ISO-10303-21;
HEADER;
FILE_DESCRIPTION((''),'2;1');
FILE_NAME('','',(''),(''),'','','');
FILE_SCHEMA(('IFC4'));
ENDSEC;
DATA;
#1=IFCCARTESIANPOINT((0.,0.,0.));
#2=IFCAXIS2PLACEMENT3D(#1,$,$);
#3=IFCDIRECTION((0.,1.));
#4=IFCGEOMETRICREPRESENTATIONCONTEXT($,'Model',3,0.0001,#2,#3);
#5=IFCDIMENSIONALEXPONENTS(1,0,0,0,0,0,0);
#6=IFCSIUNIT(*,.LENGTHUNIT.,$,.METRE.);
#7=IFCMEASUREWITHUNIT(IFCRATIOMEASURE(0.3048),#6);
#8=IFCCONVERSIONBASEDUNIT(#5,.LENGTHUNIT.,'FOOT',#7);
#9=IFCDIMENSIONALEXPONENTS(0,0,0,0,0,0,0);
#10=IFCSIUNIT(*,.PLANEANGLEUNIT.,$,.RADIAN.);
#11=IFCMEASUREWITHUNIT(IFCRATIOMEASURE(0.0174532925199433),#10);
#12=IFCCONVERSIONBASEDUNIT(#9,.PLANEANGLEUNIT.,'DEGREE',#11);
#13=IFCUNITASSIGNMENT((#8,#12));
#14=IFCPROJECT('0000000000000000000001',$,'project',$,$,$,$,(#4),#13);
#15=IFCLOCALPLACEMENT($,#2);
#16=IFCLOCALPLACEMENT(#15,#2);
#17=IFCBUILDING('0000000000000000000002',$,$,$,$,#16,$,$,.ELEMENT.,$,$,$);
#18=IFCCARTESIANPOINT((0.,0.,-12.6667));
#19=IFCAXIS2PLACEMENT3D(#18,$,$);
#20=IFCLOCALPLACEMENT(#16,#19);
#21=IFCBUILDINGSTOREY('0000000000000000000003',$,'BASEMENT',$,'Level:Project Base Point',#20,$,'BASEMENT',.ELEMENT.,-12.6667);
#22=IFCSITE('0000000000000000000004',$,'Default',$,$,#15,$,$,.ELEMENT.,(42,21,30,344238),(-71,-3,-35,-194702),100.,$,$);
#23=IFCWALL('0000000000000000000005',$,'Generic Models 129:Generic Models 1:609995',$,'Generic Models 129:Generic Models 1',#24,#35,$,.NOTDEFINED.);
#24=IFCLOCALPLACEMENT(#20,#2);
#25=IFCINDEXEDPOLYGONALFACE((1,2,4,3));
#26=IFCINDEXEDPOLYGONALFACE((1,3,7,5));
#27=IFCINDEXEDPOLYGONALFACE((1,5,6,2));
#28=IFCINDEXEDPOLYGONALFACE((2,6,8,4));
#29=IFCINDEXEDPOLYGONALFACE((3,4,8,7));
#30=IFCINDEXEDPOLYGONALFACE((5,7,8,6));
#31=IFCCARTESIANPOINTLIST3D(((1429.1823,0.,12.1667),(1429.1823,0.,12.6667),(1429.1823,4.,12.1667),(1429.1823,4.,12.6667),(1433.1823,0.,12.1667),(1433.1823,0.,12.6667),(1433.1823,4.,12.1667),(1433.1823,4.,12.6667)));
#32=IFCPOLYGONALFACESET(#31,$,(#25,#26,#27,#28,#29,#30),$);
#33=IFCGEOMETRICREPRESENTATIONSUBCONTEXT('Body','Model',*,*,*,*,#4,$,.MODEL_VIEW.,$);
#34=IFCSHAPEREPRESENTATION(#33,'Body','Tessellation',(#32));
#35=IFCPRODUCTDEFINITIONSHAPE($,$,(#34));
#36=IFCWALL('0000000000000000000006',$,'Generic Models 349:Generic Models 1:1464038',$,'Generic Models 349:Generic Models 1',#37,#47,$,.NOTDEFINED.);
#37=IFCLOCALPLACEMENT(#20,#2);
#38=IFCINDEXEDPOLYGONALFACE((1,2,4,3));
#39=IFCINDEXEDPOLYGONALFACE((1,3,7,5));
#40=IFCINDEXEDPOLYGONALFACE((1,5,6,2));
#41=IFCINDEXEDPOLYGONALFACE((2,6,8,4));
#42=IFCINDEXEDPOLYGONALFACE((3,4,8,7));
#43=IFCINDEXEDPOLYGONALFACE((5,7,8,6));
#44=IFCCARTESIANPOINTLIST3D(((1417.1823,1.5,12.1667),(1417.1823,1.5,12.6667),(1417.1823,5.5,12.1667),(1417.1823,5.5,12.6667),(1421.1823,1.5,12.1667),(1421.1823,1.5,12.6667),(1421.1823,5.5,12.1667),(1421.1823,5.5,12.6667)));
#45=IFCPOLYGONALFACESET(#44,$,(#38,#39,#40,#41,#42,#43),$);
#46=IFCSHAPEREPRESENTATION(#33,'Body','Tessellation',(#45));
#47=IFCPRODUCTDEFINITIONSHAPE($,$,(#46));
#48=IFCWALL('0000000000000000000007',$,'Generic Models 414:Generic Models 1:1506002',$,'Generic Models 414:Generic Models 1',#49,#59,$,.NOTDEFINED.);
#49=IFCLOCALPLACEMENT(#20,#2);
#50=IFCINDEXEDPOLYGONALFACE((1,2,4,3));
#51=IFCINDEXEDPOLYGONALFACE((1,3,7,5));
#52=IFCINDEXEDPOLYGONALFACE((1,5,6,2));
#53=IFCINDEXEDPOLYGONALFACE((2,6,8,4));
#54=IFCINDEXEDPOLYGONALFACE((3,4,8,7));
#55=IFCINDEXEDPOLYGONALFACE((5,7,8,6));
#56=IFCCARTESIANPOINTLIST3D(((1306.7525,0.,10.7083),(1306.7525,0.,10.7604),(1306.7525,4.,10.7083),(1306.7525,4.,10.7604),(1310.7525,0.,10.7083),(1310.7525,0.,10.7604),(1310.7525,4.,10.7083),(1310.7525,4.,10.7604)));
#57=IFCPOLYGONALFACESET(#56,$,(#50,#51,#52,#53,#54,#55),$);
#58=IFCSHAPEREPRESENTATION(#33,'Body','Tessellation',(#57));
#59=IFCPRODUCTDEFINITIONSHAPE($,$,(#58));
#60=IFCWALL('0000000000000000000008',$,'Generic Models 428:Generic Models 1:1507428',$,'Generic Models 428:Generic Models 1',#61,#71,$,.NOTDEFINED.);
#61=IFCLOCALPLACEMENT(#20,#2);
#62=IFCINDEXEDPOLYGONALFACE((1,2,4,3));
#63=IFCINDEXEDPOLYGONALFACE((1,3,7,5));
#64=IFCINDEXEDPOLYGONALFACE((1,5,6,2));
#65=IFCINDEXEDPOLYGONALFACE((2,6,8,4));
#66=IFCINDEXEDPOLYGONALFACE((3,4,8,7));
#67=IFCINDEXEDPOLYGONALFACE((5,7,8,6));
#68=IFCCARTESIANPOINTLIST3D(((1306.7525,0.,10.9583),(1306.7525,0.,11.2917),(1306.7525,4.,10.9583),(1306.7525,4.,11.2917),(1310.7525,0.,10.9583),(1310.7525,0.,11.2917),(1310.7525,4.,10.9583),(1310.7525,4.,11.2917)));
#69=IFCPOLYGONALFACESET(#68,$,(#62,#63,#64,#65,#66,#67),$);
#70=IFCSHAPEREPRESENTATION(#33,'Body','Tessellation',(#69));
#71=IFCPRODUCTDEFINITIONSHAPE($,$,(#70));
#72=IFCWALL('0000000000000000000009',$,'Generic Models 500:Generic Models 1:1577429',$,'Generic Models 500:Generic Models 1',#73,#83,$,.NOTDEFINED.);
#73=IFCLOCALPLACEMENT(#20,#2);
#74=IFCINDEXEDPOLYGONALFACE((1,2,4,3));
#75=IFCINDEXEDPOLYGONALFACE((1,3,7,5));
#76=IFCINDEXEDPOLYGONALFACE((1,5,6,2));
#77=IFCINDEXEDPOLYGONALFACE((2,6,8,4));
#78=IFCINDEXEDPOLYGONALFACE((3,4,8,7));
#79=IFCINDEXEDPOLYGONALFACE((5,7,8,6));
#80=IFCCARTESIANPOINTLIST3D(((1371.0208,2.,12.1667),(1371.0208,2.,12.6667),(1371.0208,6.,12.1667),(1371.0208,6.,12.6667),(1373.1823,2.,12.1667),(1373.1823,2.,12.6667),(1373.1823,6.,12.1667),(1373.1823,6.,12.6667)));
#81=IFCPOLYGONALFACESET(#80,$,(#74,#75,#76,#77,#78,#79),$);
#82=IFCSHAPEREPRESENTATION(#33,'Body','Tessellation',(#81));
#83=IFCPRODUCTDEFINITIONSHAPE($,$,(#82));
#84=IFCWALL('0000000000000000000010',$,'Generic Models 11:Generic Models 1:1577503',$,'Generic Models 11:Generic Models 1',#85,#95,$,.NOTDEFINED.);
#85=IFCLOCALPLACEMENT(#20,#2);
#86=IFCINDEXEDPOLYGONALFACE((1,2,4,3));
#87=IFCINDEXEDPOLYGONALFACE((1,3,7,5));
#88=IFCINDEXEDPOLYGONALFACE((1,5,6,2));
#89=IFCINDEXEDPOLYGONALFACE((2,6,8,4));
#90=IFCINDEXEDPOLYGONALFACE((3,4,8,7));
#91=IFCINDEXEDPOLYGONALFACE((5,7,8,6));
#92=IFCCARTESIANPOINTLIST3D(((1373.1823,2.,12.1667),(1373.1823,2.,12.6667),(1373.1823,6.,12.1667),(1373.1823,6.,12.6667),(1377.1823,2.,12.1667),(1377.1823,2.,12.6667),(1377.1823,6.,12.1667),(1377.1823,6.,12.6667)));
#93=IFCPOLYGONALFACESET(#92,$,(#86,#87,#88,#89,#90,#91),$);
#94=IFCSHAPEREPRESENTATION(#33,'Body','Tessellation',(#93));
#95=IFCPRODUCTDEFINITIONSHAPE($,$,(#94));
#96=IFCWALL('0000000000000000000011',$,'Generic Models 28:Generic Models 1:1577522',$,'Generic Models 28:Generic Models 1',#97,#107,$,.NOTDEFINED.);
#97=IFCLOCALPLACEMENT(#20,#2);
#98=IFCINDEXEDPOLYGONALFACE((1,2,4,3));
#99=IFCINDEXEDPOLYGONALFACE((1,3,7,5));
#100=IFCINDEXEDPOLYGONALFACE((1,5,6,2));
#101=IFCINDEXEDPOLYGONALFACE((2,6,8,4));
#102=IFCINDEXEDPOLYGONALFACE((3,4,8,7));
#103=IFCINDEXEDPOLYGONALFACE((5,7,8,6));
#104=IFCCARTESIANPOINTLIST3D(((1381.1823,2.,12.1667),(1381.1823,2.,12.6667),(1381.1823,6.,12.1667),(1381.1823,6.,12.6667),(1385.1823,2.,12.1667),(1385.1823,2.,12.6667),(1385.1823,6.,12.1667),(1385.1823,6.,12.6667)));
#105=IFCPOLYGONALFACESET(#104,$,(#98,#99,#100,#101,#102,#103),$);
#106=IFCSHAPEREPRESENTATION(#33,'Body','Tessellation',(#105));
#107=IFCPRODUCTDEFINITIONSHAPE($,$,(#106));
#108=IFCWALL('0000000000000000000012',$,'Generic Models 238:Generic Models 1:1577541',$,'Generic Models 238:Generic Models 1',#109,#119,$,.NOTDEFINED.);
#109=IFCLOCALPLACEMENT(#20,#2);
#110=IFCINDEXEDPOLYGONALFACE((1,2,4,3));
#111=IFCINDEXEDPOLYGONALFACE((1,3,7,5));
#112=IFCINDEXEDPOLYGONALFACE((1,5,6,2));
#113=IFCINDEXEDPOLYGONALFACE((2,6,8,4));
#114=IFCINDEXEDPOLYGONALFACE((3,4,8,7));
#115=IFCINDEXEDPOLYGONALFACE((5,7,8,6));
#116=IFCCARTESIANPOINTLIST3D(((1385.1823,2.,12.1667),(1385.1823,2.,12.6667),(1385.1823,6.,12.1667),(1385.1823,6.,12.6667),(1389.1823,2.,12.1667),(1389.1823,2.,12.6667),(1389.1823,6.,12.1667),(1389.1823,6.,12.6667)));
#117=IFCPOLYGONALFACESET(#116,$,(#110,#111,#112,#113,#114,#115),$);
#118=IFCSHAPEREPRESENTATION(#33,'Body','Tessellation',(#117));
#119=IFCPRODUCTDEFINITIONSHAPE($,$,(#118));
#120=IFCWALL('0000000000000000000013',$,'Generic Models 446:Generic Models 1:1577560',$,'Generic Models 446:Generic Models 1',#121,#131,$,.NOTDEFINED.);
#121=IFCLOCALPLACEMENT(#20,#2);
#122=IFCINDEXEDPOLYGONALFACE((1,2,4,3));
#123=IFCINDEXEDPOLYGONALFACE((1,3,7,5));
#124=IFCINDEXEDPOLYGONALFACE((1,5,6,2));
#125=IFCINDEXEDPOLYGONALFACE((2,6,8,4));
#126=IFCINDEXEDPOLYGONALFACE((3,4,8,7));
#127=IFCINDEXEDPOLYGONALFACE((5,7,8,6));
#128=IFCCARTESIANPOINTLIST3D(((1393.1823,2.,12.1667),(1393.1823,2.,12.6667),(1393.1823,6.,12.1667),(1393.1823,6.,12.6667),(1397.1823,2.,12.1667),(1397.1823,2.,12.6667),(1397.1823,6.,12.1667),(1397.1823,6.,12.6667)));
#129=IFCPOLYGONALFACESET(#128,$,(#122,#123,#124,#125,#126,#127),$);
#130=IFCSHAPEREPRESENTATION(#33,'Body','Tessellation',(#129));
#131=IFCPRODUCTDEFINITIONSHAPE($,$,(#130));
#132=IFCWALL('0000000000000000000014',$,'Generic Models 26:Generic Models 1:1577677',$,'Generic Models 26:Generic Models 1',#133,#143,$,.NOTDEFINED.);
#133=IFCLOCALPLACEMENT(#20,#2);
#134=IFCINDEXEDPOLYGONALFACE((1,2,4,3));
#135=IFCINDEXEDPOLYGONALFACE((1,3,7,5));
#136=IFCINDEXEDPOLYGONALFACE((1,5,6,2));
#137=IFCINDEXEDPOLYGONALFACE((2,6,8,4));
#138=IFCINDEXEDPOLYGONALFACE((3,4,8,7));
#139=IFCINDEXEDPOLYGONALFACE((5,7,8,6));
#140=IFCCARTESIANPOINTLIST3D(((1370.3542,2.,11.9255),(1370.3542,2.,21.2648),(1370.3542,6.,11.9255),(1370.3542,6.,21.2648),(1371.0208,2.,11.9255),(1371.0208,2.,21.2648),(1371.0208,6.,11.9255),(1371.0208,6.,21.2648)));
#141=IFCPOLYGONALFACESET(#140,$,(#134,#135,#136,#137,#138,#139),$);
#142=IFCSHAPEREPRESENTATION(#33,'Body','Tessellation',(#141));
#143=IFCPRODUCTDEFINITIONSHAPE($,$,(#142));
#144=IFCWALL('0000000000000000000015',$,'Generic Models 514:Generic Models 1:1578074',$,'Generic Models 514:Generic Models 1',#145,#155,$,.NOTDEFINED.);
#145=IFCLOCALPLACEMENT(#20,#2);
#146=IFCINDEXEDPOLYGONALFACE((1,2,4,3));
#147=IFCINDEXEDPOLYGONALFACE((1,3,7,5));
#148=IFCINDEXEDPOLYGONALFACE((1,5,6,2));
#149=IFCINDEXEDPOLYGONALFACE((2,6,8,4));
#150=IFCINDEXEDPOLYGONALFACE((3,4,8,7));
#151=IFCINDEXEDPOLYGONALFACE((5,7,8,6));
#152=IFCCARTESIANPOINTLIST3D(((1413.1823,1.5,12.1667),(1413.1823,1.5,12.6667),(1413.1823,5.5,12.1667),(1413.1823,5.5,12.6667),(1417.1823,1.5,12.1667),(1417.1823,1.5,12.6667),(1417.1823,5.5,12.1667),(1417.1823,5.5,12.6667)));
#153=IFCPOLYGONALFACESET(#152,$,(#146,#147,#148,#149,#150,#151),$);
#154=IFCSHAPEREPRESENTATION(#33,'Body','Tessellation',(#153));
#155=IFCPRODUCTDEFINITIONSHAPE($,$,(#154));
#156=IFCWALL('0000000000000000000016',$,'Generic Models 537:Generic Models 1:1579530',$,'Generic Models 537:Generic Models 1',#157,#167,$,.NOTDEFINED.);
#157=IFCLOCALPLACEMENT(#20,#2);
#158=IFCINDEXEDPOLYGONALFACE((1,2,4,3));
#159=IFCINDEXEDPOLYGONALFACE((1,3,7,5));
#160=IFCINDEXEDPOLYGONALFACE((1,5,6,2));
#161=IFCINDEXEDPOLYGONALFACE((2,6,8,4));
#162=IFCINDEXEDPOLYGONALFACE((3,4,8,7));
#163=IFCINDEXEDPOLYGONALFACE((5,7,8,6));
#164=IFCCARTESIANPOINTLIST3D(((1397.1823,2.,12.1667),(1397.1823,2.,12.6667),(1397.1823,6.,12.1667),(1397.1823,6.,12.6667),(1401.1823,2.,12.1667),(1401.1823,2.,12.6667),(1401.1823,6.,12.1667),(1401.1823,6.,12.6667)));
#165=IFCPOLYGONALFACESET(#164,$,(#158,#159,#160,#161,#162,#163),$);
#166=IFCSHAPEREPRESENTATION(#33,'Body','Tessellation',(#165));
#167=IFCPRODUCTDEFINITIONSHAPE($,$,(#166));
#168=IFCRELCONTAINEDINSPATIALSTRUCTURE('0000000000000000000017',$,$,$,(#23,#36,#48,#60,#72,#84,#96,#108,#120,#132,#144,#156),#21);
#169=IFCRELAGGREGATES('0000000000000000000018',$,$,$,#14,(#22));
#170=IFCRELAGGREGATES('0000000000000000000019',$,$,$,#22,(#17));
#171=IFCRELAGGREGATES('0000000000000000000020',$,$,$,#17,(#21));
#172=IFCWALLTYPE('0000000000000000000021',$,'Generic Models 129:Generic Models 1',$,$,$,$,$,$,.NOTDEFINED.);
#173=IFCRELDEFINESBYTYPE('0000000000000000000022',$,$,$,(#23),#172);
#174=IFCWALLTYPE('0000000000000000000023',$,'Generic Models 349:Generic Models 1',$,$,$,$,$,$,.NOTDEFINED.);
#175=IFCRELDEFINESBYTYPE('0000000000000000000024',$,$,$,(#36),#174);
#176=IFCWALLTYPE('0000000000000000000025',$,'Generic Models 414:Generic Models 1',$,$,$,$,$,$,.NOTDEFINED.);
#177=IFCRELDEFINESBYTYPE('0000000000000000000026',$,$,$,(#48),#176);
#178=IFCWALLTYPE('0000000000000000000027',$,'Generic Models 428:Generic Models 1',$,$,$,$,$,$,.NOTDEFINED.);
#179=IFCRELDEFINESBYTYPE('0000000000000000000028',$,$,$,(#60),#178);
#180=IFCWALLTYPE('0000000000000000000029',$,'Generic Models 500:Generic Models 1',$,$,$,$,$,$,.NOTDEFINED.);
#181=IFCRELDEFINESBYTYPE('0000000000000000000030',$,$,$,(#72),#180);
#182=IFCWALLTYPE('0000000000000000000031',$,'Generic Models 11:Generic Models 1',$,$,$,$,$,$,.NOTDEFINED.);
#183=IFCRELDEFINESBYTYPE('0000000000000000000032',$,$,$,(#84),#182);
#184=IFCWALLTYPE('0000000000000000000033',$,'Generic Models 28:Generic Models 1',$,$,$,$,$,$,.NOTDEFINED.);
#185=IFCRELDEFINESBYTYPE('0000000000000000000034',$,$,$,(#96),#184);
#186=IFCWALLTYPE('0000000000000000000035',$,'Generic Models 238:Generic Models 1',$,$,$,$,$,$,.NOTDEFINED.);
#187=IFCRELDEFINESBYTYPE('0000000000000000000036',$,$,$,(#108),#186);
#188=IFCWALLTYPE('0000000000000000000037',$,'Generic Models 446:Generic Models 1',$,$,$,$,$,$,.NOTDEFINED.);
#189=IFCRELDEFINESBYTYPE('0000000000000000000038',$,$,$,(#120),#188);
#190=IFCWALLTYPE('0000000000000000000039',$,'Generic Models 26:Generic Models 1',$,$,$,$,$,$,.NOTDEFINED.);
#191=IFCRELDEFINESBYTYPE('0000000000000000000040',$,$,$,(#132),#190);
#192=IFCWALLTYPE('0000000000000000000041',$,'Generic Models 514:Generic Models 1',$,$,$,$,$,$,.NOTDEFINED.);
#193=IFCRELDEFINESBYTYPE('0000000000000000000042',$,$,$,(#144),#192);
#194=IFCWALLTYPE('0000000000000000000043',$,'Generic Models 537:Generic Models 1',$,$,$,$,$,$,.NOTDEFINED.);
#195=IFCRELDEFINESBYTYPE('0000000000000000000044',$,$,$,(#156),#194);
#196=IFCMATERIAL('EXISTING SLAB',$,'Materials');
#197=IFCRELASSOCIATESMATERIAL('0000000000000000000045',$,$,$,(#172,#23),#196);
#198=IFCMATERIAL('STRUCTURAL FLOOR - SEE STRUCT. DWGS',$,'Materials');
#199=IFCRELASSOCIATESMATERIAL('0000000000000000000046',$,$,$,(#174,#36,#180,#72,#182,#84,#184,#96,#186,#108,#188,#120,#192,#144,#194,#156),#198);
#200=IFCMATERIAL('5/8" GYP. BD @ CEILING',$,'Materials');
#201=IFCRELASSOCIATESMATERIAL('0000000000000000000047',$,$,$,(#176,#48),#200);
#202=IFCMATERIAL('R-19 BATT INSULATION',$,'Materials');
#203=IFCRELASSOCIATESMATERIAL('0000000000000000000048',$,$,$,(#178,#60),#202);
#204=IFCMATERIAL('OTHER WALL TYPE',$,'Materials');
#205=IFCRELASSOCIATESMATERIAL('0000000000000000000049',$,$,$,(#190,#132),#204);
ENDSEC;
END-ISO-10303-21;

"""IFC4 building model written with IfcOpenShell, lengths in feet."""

from ifc_helpers import new_model, entity, si_unit, converted_unit, direction, frame, frame_2d, origin, origin_2d_with_axis, place, context, subcontext, project, spatial, rectangle, extrude, material, type_object, element, save


model = new_model("IFC4")

# Units and contexts
model_context = context("Model", 3, precision=0.0001, world=origin(), true_north=direction((0.0, 1.0)))
body_context = subcontext(model_context, "Body", "Model", "MODEL_VIEW")
ifc_project = project(units=[converted_unit("LENGTHUNIT", "FOOT", entity("IfcRatioMeasure", 0.3048), si_unit("LENGTHUNIT", "METRE"), dimensions=[1, 0, 0, 0, 0, 0, 0]), converted_unit("PLANEANGLEUNIT", "DEGREE", entity("IfcRatioMeasure", 0.0174532925199433), si_unit("PLANEANGLEUNIT", "RADIAN"), dimensions=[0, 0, 0, 0, 0, 0, 0])], contexts=[model_context])

# Site, building, storey
site_placement = place(None, origin())
site = spatial("IfcSite", under=ifc_project, at=site_placement, Name="Default", CompositionType="ELEMENT", RefLatitude=(42, 21, 30, 344238), RefLongitude=(-71, -3, -35, -194702), RefElevation=100.0)
building_placement = place(site_placement, origin())
building = spatial("IfcBuilding", under=site, at=building_placement, CompositionType="ELEMENT")
storey_placement = place(building_placement, frame((0.0, 0.0, -12.6667)))
storey = spatial("IfcBuildingStorey", under=building, at=storey_placement, Name="BASEMENT", ObjectType="Level:Project Base Point", LongName="BASEMENT", CompositionType="ELEMENT", Elevation=-12.6667)

# Walls
ifc_material_1 = material(Name="EXISTING SLAB", Category="Materials")
wall_type_1 = type_object("IfcWallType", Name="Generic Models 129:Generic Models 1", PredefinedType="NOTDEFINED", material=ifc_material_1)
wall_1_placement = place(storey_placement, frame((1429.1823, 0.0, 12.1667), z_axis=(0.0, 0.0, 1.0), x_axis=(0.0, 1.0, 0.0)))
element("IfcWall", 1, at=wall_1_placement, inside=storey, type_object=wall_type_1, material=ifc_material_1, Name="Generic Models 129:Generic Models 1:609995", ObjectType="Generic Models 129:Generic Models 1", PredefinedType="NOTDEFINED", context=body_context, shape_type="SweptSolid", body=[
    extrude(rectangle(XDim=4.0, YDim=4.0, at=frame_2d((0.0, 0.0), x_axis=(1.0, 0.0))), frame((2.0, -2.0, 0.0)), (0.0, 0.0, 1.0), 0.5),
])
ifc_material_2 = material(Name="STRUCTURAL FLOOR - SEE STRUCT. DWGS", Category="Materials")
wall_type_2 = type_object("IfcWallType", Name="Generic Models 349:Generic Models 1", PredefinedType="NOTDEFINED", material=ifc_material_2)
wall_2_placement = place(storey_placement, frame((1417.1823, 1.5, 12.1667), z_axis=(0.0, 0.0, 1.0), x_axis=(0.0, 1.0, 0.0)))
element("IfcWall", 2, at=wall_2_placement, inside=storey, type_object=wall_type_2, material=ifc_material_2, Name="Generic Models 349:Generic Models 1:1464038", ObjectType="Generic Models 349:Generic Models 1", PredefinedType="NOTDEFINED", context=body_context, shape_type="SweptSolid", body=[
    extrude(rectangle(XDim=4.0, YDim=4.0, at=frame_2d((0.0, 0.0), x_axis=(1.0, 0.0))), frame((2.0, -2.0, 0.0)), (0.0, 0.0, 1.0), 0.5),
])
ifc_material_3 = material(Name="5/8\" GYP. BD @ CEILING", Category="Materials")
wall_type_3 = type_object("IfcWallType", Name="Generic Models 414:Generic Models 1", PredefinedType="NOTDEFINED", material=ifc_material_3)
wall_3_placement = place(storey_placement, frame((1306.7525, 0.0, 10.7083), z_axis=(0.0, 0.0, 1.0), x_axis=(0.0, 1.0, 0.0)))
element("IfcWall", 3, at=wall_3_placement, inside=storey, type_object=wall_type_3, material=ifc_material_3, Name="Generic Models 414:Generic Models 1:1506002", ObjectType="Generic Models 414:Generic Models 1", PredefinedType="NOTDEFINED", context=body_context, shape_type="SweptSolid", body=[
    extrude(rectangle(XDim=4.0, YDim=4.0, at=origin_2d_with_axis()), frame((2.0, -2.0, 0.0)), (0.0, 0.0, 1.0), 0.0521),
])
ifc_material_4 = material(Name="R-19 BATT INSULATION", Category="Materials")
wall_type_4 = type_object("IfcWallType", Name="Generic Models 428:Generic Models 1", PredefinedType="NOTDEFINED", material=ifc_material_4)
wall_4_placement = place(storey_placement, frame((1306.7525, 0.0, 10.9583), z_axis=(0.0, 0.0, 1.0), x_axis=(0.0, 1.0, 0.0)))
element("IfcWall", 4, at=wall_4_placement, inside=storey, type_object=wall_type_4, material=ifc_material_4, Name="Generic Models 428:Generic Models 1:1507428", ObjectType="Generic Models 428:Generic Models 1", PredefinedType="NOTDEFINED", context=body_context, shape_type="SweptSolid", body=[
    extrude(rectangle(XDim=4.0, YDim=4.0, at=origin_2d_with_axis()), frame((2.0, -2.0, 0.0)), (0.0, 0.0, 1.0), 0.3333),
])
wall_type_5 = type_object("IfcWallType", Name="Generic Models 500:Generic Models 1", PredefinedType="NOTDEFINED", material=ifc_material_2)
wall_5_placement = place(storey_placement, frame((1371.0208, 2.0, 12.1667), z_axis=(0.0, 0.0, 1.0), x_axis=(0.0, 1.0, 0.0)))
element("IfcWall", 5, at=wall_5_placement, inside=storey, type_object=wall_type_5, material=ifc_material_2, Name="Generic Models 500:Generic Models 1:1577429", ObjectType="Generic Models 500:Generic Models 1", PredefinedType="NOTDEFINED", context=body_context, shape_type="SweptSolid", body=[
    extrude(rectangle(XDim=4.0, YDim=2.1615, at=frame_2d((0.0, 0.0), x_axis=(1.0, 0.0))), frame((2.0, -1.0807, 0.0)), (0.0, 0.0, 1.0), 0.5),
])
wall_type_6 = type_object("IfcWallType", Name="Generic Models 11:Generic Models 1", PredefinedType="NOTDEFINED", material=ifc_material_2)
wall_6_placement = place(storey_placement, frame((1373.1823, 2.0, 12.1667), z_axis=(0.0, 0.0, 1.0), x_axis=(0.0, 1.0, 0.0)))
element("IfcWall", 6, at=wall_6_placement, inside=storey, type_object=wall_type_6, material=ifc_material_2, Name="Generic Models 11:Generic Models 1:1577503", ObjectType="Generic Models 11:Generic Models 1", PredefinedType="NOTDEFINED", context=body_context, shape_type="SweptSolid", body=[
    extrude(rectangle(XDim=4.0, YDim=4.0, at=origin_2d_with_axis()), frame((2.0, -2.0, 0.0)), (0.0, 0.0, 1.0), 0.5),
])
wall_type_7 = type_object("IfcWallType", Name="Generic Models 28:Generic Models 1", PredefinedType="NOTDEFINED", material=ifc_material_2)
wall_7_placement = place(storey_placement, frame((1381.1823, 2.0, 12.1667), z_axis=(0.0, 0.0, 1.0), x_axis=(0.0, 1.0, 0.0)))
element("IfcWall", 7, at=wall_7_placement, inside=storey, type_object=wall_type_7, material=ifc_material_2, Name="Generic Models 28:Generic Models 1:1577522", ObjectType="Generic Models 28:Generic Models 1", PredefinedType="NOTDEFINED", context=body_context, shape_type="SweptSolid", body=[
    extrude(rectangle(XDim=4.0, YDim=4.0, at=frame_2d((0.0, 0.0), x_axis=(1.0, 0.0))), frame((2.0, -2.0, 0.0)), (0.0, 0.0, 1.0), 0.5),
])
wall_type_8 = type_object("IfcWallType", Name="Generic Models 238:Generic Models 1", PredefinedType="NOTDEFINED", material=ifc_material_2)
wall_8_placement = place(storey_placement, frame((1385.1823, 2.0, 12.1667), z_axis=(0.0, 0.0, 1.0), x_axis=(0.0, 1.0, 0.0)))
element("IfcWall", 8, at=wall_8_placement, inside=storey, type_object=wall_type_8, material=ifc_material_2, Name="Generic Models 238:Generic Models 1:1577541", ObjectType="Generic Models 238:Generic Models 1", PredefinedType="NOTDEFINED", context=body_context, shape_type="SweptSolid", body=[
    extrude(rectangle(XDim=4.0, YDim=4.0, at=frame_2d((0.0, 0.0), x_axis=(1.0, 0.0))), frame((2.0, -2.0, 0.0)), (0.0, 0.0, 1.0), 0.5),
])
wall_type_9 = type_object("IfcWallType", Name="Generic Models 446:Generic Models 1", PredefinedType="NOTDEFINED", material=ifc_material_2)
wall_9_placement = place(storey_placement, frame((1393.1823, 2.0, 12.1667), z_axis=(0.0, 0.0, 1.0), x_axis=(0.0, 1.0, 0.0)))
element("IfcWall", 9, at=wall_9_placement, inside=storey, type_object=wall_type_9, material=ifc_material_2, Name="Generic Models 446:Generic Models 1:1577560", ObjectType="Generic Models 446:Generic Models 1", PredefinedType="NOTDEFINED", context=body_context, shape_type="SweptSolid", body=[
    extrude(rectangle(XDim=4.0, YDim=4.0, at=origin_2d_with_axis()), frame((2.0, -2.0, 0.0)), (0.0, 0.0, 1.0), 0.5),
])
ifc_material_5 = material(Name="OTHER WALL TYPE", Category="Materials")
wall_type_10 = type_object("IfcWallType", Name="Generic Models 26:Generic Models 1", PredefinedType="NOTDEFINED", material=ifc_material_5)
wall_10_placement = place(storey_placement, frame((1370.3542, 2.0, 11.9255), z_axis=(0.0, 0.0, 1.0), x_axis=(0.0, 1.0, 0.0)))
element("IfcWall", 10, at=wall_10_placement, inside=storey, type_object=wall_type_10, material=ifc_material_5, Name="Generic Models 26:Generic Models 1:1577677", ObjectType="Generic Models 26:Generic Models 1", PredefinedType="NOTDEFINED", context=body_context, shape_type="SweptSolid", body=[
    extrude(rectangle(XDim=4.0, YDim=0.6667, at=frame_2d((0.0, 0.0), x_axis=(1.0, 0.0))), frame((2.0, -0.3333, 0.0)), (0.0, 0.0, 1.0), 9.3393),
])
wall_type_11 = type_object("IfcWallType", Name="Generic Models 514:Generic Models 1", PredefinedType="NOTDEFINED", material=ifc_material_2)
wall_11_placement = place(storey_placement, frame((1413.1823, 1.5, 12.1667), z_axis=(0.0, 0.0, 1.0), x_axis=(0.0, 1.0, 0.0)))
element("IfcWall", 11, at=wall_11_placement, inside=storey, type_object=wall_type_11, material=ifc_material_2, Name="Generic Models 514:Generic Models 1:1578074", ObjectType="Generic Models 514:Generic Models 1", PredefinedType="NOTDEFINED", context=body_context, shape_type="SweptSolid", body=[
    extrude(rectangle(XDim=4.0, YDim=4.0, at=frame_2d((0.0, 0.0), x_axis=(1.0, 0.0))), frame((2.0, -2.0, 0.0)), (0.0, 0.0, 1.0), 0.5),
])
wall_type_12 = type_object("IfcWallType", Name="Generic Models 537:Generic Models 1", PredefinedType="NOTDEFINED", material=ifc_material_2)
wall_12_placement = place(storey_placement, frame((1397.1823, 2.0, 12.1667), z_axis=(0.0, 0.0, 1.0), x_axis=(0.0, 1.0, 0.0)))
element("IfcWall", 12, at=wall_12_placement, inside=storey, type_object=wall_type_12, material=ifc_material_2, Name="Generic Models 537:Generic Models 1:1579530", ObjectType="Generic Models 537:Generic Models 1", PredefinedType="NOTDEFINED", context=body_context, shape_type="SweptSolid", body=[
    extrude(rectangle(XDim=4.0, YDim=4.0, at=origin_2d_with_axis()), frame((2.0, -2.0, 0.0)), (0.0, 0.0, 1.0), 0.5),
])

save(model, "model.ifc")
